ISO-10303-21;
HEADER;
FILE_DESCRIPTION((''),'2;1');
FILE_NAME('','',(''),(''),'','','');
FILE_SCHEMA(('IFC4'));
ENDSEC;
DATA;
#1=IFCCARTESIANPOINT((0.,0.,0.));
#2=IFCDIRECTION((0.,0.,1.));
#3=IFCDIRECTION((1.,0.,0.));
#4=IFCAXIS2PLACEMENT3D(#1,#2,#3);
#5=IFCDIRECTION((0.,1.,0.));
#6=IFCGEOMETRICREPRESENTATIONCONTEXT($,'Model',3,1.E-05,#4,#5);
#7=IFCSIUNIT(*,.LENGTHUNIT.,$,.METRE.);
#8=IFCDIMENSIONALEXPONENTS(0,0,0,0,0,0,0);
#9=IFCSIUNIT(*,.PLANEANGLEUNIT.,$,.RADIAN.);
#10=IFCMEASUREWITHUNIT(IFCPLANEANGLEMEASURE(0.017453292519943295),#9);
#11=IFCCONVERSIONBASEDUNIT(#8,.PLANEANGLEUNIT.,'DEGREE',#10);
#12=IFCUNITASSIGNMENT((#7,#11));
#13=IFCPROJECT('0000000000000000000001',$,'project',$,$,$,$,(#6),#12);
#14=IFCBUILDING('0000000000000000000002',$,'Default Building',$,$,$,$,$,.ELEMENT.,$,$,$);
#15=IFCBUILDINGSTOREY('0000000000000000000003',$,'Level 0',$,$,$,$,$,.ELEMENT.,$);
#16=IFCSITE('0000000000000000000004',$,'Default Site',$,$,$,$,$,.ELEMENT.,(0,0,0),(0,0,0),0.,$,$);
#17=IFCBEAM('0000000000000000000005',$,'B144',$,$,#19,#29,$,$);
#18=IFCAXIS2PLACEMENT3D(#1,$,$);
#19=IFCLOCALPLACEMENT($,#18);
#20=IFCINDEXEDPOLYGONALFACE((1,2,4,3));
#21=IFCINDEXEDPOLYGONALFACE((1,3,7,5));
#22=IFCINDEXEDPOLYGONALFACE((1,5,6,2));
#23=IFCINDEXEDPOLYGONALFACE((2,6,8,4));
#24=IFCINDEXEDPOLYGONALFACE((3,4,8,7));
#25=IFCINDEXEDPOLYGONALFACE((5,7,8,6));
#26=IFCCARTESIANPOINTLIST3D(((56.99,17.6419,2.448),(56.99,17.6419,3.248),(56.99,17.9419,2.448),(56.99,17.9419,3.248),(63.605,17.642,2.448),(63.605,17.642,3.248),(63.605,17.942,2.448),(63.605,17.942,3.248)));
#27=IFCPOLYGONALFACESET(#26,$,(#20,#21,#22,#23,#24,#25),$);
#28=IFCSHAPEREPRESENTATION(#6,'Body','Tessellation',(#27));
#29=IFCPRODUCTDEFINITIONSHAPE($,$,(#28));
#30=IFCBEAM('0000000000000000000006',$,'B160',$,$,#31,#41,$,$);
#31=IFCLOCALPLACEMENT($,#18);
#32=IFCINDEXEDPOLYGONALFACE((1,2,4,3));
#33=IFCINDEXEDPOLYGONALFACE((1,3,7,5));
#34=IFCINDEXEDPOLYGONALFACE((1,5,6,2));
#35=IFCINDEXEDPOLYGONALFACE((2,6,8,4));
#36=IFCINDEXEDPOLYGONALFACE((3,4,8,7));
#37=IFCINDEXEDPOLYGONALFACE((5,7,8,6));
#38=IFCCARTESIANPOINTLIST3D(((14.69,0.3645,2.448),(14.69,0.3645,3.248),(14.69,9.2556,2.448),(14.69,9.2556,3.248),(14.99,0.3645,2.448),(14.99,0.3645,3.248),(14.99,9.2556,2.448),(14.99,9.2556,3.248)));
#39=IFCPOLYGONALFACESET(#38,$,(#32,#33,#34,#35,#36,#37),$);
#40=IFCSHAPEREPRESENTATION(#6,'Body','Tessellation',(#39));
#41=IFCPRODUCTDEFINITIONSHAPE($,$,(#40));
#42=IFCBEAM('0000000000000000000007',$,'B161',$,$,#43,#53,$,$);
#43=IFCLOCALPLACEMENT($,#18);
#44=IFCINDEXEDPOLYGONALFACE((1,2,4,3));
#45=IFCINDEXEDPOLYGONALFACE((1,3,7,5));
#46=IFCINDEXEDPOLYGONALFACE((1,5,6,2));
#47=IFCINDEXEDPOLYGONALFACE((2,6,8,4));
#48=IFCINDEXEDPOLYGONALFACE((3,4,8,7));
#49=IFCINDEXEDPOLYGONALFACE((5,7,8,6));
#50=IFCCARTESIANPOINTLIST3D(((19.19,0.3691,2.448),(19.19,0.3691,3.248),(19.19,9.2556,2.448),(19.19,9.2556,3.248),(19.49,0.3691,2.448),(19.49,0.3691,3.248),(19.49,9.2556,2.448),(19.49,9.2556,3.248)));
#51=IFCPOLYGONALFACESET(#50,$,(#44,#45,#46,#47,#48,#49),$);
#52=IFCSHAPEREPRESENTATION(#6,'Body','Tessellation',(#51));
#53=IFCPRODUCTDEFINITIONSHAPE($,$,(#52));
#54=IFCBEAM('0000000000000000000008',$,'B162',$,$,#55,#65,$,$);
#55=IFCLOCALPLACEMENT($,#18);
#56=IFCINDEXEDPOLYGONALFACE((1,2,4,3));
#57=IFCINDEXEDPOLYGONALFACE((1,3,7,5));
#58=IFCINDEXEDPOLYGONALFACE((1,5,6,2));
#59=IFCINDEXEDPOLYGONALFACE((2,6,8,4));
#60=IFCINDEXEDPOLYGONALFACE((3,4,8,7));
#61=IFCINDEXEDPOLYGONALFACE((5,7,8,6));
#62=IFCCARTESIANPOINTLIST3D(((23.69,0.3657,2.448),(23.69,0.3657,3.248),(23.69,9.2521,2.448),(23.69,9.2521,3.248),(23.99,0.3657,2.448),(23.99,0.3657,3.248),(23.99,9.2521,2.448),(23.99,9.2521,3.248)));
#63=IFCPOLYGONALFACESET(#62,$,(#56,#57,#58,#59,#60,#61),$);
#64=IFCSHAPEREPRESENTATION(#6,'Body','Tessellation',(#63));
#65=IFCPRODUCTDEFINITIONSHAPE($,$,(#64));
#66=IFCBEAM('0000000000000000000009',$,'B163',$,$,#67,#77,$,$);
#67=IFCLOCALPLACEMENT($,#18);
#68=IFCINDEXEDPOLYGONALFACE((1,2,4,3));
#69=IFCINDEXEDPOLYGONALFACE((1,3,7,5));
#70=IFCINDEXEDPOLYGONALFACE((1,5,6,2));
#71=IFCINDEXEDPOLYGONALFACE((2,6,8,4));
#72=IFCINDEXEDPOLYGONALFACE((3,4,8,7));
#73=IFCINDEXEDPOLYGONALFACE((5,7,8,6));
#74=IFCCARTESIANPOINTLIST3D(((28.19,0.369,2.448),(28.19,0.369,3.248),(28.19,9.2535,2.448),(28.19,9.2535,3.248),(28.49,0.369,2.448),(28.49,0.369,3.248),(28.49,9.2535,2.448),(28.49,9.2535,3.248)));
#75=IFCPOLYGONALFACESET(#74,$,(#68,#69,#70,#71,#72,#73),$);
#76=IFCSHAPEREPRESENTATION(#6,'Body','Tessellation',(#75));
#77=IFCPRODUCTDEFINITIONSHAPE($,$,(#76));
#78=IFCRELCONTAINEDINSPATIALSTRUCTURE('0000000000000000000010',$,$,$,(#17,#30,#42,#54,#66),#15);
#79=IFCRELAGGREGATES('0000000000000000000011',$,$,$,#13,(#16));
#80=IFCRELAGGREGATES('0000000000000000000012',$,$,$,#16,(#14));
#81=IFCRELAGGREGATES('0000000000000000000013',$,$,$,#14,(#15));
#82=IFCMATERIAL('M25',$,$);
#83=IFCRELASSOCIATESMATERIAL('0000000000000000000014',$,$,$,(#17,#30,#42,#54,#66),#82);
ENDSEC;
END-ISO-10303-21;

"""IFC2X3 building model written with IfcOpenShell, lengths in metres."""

from ifc_helpers import new_model, entity, si_unit, converted_unit, direction, frame, frame_2d, origin_with_axes, place, context, project, spatial, rectangle, extrude, material, element, save


model = new_model("IFC2X3")

# Units and contexts
model_context = context("Model", 3, precision=1e-05, world=origin_with_axes(), true_north=direction((0.0, 1.0, 0.0)))
ifc_project = project(units=[si_unit("LENGTHUNIT", "METRE"), converted_unit("PLANEANGLEUNIT", "DEGREE", entity("IfcPlaneAngleMeasure", 0.017453292519943295), si_unit("PLANEANGLEUNIT", "RADIAN"), dimensions=[0, 0, 0, 0, 0, 0, 0])], contexts=[model_context])

# Site, building, storey
site = spatial("IfcSite", under=ifc_project, Name="Default Site", CompositionType="ELEMENT", RefLatitude=(0, 0, 0), RefLongitude=(0, 0, 0), RefElevation=0.0)
building = spatial("IfcBuilding", under=site, Name="Default Building", CompositionType="ELEMENT")
storey = spatial("IfcBuildingStorey", under=building, Name="Level 0", CompositionType="ELEMENT")

# Beams
ifc_material = material(Name="M25")
placement = place(None, origin_with_axes())
element("IfcBeam", 1, at=placement, inside=storey, material=ifc_material, Name="B144", context=model_context, shape_type="SweptSolid", body=[
    extrude(rectangle(XDim=0.3, YDim=0.8, at=frame_2d((0.0, 0.0), x_axis=(0.0, 1.0, 0.0))), frame((56.99, 17.7919, 2.848), z_axis=(1.0, 0.00002, 0.0), x_axis=(0.0, 0.0, -1.0)), (0.0, 0.0, 1.0), 6.615),
])
element("IfcBeam", 2, at=placement, inside=storey, material=ifc_material, Name="B160", context=model_context, shape_type="SweptSolid", body=[
    extrude(rectangle(XDim=0.3, YDim=0.8, at=frame_2d((0.0, 0.0), x_axis=(0.0, 1.0, 0.0))), frame((14.84, 0.3645, 2.848), z_axis=(0.0, 1.0, 0.0), x_axis=(0.0, 0.0, -1.0)), (0.0, 0.0, 1.0), 8.891),
])
element("IfcBeam", 3, at=placement, inside=storey, material=ifc_material, Name="B161", context=model_context, shape_type="SweptSolid", body=[
    extrude(rectangle(XDim=0.3, YDim=0.8, at=frame_2d((0.0, 0.0), x_axis=(0.0, 1.0, 0.0))), frame((19.34, 0.3691, 2.848), z_axis=(0.0, 1.0, 0.0), x_axis=(0.0, 0.0, -1.0)), (0.0, 0.0, 1.0), 8.8865),
])
element("IfcBeam", 4, at=placement, inside=storey, material=ifc_material, Name="B162", context=model_context, shape_type="SweptSolid", body=[
    extrude(rectangle(XDim=0.3, YDim=0.8, at=frame_2d((0.0, 0.0), x_axis=(0.0, 1.0, 0.0))), frame((23.84, 0.3657, 2.848), z_axis=(0.0, 1.0, 0.0), x_axis=(0.0, 0.0, -1.0)), (0.0, 0.0, 1.0), 8.8864),
])
element("IfcBeam", 5, at=placement, inside=storey, material=ifc_material, Name="B163", context=model_context, shape_type="SweptSolid", body=[
    extrude(rectangle(XDim=0.3, YDim=0.8, at=frame_2d((0.0, 0.0), x_axis=(0.0, 1.0, 0.0))), frame((28.34, 0.369, 2.848), z_axis=(0.0, 1.0, 0.0), x_axis=(0.0, 0.0, -1.0)), (0.0, 0.0, 1.0), 8.8845),
])

save(model, "model.ifc")
